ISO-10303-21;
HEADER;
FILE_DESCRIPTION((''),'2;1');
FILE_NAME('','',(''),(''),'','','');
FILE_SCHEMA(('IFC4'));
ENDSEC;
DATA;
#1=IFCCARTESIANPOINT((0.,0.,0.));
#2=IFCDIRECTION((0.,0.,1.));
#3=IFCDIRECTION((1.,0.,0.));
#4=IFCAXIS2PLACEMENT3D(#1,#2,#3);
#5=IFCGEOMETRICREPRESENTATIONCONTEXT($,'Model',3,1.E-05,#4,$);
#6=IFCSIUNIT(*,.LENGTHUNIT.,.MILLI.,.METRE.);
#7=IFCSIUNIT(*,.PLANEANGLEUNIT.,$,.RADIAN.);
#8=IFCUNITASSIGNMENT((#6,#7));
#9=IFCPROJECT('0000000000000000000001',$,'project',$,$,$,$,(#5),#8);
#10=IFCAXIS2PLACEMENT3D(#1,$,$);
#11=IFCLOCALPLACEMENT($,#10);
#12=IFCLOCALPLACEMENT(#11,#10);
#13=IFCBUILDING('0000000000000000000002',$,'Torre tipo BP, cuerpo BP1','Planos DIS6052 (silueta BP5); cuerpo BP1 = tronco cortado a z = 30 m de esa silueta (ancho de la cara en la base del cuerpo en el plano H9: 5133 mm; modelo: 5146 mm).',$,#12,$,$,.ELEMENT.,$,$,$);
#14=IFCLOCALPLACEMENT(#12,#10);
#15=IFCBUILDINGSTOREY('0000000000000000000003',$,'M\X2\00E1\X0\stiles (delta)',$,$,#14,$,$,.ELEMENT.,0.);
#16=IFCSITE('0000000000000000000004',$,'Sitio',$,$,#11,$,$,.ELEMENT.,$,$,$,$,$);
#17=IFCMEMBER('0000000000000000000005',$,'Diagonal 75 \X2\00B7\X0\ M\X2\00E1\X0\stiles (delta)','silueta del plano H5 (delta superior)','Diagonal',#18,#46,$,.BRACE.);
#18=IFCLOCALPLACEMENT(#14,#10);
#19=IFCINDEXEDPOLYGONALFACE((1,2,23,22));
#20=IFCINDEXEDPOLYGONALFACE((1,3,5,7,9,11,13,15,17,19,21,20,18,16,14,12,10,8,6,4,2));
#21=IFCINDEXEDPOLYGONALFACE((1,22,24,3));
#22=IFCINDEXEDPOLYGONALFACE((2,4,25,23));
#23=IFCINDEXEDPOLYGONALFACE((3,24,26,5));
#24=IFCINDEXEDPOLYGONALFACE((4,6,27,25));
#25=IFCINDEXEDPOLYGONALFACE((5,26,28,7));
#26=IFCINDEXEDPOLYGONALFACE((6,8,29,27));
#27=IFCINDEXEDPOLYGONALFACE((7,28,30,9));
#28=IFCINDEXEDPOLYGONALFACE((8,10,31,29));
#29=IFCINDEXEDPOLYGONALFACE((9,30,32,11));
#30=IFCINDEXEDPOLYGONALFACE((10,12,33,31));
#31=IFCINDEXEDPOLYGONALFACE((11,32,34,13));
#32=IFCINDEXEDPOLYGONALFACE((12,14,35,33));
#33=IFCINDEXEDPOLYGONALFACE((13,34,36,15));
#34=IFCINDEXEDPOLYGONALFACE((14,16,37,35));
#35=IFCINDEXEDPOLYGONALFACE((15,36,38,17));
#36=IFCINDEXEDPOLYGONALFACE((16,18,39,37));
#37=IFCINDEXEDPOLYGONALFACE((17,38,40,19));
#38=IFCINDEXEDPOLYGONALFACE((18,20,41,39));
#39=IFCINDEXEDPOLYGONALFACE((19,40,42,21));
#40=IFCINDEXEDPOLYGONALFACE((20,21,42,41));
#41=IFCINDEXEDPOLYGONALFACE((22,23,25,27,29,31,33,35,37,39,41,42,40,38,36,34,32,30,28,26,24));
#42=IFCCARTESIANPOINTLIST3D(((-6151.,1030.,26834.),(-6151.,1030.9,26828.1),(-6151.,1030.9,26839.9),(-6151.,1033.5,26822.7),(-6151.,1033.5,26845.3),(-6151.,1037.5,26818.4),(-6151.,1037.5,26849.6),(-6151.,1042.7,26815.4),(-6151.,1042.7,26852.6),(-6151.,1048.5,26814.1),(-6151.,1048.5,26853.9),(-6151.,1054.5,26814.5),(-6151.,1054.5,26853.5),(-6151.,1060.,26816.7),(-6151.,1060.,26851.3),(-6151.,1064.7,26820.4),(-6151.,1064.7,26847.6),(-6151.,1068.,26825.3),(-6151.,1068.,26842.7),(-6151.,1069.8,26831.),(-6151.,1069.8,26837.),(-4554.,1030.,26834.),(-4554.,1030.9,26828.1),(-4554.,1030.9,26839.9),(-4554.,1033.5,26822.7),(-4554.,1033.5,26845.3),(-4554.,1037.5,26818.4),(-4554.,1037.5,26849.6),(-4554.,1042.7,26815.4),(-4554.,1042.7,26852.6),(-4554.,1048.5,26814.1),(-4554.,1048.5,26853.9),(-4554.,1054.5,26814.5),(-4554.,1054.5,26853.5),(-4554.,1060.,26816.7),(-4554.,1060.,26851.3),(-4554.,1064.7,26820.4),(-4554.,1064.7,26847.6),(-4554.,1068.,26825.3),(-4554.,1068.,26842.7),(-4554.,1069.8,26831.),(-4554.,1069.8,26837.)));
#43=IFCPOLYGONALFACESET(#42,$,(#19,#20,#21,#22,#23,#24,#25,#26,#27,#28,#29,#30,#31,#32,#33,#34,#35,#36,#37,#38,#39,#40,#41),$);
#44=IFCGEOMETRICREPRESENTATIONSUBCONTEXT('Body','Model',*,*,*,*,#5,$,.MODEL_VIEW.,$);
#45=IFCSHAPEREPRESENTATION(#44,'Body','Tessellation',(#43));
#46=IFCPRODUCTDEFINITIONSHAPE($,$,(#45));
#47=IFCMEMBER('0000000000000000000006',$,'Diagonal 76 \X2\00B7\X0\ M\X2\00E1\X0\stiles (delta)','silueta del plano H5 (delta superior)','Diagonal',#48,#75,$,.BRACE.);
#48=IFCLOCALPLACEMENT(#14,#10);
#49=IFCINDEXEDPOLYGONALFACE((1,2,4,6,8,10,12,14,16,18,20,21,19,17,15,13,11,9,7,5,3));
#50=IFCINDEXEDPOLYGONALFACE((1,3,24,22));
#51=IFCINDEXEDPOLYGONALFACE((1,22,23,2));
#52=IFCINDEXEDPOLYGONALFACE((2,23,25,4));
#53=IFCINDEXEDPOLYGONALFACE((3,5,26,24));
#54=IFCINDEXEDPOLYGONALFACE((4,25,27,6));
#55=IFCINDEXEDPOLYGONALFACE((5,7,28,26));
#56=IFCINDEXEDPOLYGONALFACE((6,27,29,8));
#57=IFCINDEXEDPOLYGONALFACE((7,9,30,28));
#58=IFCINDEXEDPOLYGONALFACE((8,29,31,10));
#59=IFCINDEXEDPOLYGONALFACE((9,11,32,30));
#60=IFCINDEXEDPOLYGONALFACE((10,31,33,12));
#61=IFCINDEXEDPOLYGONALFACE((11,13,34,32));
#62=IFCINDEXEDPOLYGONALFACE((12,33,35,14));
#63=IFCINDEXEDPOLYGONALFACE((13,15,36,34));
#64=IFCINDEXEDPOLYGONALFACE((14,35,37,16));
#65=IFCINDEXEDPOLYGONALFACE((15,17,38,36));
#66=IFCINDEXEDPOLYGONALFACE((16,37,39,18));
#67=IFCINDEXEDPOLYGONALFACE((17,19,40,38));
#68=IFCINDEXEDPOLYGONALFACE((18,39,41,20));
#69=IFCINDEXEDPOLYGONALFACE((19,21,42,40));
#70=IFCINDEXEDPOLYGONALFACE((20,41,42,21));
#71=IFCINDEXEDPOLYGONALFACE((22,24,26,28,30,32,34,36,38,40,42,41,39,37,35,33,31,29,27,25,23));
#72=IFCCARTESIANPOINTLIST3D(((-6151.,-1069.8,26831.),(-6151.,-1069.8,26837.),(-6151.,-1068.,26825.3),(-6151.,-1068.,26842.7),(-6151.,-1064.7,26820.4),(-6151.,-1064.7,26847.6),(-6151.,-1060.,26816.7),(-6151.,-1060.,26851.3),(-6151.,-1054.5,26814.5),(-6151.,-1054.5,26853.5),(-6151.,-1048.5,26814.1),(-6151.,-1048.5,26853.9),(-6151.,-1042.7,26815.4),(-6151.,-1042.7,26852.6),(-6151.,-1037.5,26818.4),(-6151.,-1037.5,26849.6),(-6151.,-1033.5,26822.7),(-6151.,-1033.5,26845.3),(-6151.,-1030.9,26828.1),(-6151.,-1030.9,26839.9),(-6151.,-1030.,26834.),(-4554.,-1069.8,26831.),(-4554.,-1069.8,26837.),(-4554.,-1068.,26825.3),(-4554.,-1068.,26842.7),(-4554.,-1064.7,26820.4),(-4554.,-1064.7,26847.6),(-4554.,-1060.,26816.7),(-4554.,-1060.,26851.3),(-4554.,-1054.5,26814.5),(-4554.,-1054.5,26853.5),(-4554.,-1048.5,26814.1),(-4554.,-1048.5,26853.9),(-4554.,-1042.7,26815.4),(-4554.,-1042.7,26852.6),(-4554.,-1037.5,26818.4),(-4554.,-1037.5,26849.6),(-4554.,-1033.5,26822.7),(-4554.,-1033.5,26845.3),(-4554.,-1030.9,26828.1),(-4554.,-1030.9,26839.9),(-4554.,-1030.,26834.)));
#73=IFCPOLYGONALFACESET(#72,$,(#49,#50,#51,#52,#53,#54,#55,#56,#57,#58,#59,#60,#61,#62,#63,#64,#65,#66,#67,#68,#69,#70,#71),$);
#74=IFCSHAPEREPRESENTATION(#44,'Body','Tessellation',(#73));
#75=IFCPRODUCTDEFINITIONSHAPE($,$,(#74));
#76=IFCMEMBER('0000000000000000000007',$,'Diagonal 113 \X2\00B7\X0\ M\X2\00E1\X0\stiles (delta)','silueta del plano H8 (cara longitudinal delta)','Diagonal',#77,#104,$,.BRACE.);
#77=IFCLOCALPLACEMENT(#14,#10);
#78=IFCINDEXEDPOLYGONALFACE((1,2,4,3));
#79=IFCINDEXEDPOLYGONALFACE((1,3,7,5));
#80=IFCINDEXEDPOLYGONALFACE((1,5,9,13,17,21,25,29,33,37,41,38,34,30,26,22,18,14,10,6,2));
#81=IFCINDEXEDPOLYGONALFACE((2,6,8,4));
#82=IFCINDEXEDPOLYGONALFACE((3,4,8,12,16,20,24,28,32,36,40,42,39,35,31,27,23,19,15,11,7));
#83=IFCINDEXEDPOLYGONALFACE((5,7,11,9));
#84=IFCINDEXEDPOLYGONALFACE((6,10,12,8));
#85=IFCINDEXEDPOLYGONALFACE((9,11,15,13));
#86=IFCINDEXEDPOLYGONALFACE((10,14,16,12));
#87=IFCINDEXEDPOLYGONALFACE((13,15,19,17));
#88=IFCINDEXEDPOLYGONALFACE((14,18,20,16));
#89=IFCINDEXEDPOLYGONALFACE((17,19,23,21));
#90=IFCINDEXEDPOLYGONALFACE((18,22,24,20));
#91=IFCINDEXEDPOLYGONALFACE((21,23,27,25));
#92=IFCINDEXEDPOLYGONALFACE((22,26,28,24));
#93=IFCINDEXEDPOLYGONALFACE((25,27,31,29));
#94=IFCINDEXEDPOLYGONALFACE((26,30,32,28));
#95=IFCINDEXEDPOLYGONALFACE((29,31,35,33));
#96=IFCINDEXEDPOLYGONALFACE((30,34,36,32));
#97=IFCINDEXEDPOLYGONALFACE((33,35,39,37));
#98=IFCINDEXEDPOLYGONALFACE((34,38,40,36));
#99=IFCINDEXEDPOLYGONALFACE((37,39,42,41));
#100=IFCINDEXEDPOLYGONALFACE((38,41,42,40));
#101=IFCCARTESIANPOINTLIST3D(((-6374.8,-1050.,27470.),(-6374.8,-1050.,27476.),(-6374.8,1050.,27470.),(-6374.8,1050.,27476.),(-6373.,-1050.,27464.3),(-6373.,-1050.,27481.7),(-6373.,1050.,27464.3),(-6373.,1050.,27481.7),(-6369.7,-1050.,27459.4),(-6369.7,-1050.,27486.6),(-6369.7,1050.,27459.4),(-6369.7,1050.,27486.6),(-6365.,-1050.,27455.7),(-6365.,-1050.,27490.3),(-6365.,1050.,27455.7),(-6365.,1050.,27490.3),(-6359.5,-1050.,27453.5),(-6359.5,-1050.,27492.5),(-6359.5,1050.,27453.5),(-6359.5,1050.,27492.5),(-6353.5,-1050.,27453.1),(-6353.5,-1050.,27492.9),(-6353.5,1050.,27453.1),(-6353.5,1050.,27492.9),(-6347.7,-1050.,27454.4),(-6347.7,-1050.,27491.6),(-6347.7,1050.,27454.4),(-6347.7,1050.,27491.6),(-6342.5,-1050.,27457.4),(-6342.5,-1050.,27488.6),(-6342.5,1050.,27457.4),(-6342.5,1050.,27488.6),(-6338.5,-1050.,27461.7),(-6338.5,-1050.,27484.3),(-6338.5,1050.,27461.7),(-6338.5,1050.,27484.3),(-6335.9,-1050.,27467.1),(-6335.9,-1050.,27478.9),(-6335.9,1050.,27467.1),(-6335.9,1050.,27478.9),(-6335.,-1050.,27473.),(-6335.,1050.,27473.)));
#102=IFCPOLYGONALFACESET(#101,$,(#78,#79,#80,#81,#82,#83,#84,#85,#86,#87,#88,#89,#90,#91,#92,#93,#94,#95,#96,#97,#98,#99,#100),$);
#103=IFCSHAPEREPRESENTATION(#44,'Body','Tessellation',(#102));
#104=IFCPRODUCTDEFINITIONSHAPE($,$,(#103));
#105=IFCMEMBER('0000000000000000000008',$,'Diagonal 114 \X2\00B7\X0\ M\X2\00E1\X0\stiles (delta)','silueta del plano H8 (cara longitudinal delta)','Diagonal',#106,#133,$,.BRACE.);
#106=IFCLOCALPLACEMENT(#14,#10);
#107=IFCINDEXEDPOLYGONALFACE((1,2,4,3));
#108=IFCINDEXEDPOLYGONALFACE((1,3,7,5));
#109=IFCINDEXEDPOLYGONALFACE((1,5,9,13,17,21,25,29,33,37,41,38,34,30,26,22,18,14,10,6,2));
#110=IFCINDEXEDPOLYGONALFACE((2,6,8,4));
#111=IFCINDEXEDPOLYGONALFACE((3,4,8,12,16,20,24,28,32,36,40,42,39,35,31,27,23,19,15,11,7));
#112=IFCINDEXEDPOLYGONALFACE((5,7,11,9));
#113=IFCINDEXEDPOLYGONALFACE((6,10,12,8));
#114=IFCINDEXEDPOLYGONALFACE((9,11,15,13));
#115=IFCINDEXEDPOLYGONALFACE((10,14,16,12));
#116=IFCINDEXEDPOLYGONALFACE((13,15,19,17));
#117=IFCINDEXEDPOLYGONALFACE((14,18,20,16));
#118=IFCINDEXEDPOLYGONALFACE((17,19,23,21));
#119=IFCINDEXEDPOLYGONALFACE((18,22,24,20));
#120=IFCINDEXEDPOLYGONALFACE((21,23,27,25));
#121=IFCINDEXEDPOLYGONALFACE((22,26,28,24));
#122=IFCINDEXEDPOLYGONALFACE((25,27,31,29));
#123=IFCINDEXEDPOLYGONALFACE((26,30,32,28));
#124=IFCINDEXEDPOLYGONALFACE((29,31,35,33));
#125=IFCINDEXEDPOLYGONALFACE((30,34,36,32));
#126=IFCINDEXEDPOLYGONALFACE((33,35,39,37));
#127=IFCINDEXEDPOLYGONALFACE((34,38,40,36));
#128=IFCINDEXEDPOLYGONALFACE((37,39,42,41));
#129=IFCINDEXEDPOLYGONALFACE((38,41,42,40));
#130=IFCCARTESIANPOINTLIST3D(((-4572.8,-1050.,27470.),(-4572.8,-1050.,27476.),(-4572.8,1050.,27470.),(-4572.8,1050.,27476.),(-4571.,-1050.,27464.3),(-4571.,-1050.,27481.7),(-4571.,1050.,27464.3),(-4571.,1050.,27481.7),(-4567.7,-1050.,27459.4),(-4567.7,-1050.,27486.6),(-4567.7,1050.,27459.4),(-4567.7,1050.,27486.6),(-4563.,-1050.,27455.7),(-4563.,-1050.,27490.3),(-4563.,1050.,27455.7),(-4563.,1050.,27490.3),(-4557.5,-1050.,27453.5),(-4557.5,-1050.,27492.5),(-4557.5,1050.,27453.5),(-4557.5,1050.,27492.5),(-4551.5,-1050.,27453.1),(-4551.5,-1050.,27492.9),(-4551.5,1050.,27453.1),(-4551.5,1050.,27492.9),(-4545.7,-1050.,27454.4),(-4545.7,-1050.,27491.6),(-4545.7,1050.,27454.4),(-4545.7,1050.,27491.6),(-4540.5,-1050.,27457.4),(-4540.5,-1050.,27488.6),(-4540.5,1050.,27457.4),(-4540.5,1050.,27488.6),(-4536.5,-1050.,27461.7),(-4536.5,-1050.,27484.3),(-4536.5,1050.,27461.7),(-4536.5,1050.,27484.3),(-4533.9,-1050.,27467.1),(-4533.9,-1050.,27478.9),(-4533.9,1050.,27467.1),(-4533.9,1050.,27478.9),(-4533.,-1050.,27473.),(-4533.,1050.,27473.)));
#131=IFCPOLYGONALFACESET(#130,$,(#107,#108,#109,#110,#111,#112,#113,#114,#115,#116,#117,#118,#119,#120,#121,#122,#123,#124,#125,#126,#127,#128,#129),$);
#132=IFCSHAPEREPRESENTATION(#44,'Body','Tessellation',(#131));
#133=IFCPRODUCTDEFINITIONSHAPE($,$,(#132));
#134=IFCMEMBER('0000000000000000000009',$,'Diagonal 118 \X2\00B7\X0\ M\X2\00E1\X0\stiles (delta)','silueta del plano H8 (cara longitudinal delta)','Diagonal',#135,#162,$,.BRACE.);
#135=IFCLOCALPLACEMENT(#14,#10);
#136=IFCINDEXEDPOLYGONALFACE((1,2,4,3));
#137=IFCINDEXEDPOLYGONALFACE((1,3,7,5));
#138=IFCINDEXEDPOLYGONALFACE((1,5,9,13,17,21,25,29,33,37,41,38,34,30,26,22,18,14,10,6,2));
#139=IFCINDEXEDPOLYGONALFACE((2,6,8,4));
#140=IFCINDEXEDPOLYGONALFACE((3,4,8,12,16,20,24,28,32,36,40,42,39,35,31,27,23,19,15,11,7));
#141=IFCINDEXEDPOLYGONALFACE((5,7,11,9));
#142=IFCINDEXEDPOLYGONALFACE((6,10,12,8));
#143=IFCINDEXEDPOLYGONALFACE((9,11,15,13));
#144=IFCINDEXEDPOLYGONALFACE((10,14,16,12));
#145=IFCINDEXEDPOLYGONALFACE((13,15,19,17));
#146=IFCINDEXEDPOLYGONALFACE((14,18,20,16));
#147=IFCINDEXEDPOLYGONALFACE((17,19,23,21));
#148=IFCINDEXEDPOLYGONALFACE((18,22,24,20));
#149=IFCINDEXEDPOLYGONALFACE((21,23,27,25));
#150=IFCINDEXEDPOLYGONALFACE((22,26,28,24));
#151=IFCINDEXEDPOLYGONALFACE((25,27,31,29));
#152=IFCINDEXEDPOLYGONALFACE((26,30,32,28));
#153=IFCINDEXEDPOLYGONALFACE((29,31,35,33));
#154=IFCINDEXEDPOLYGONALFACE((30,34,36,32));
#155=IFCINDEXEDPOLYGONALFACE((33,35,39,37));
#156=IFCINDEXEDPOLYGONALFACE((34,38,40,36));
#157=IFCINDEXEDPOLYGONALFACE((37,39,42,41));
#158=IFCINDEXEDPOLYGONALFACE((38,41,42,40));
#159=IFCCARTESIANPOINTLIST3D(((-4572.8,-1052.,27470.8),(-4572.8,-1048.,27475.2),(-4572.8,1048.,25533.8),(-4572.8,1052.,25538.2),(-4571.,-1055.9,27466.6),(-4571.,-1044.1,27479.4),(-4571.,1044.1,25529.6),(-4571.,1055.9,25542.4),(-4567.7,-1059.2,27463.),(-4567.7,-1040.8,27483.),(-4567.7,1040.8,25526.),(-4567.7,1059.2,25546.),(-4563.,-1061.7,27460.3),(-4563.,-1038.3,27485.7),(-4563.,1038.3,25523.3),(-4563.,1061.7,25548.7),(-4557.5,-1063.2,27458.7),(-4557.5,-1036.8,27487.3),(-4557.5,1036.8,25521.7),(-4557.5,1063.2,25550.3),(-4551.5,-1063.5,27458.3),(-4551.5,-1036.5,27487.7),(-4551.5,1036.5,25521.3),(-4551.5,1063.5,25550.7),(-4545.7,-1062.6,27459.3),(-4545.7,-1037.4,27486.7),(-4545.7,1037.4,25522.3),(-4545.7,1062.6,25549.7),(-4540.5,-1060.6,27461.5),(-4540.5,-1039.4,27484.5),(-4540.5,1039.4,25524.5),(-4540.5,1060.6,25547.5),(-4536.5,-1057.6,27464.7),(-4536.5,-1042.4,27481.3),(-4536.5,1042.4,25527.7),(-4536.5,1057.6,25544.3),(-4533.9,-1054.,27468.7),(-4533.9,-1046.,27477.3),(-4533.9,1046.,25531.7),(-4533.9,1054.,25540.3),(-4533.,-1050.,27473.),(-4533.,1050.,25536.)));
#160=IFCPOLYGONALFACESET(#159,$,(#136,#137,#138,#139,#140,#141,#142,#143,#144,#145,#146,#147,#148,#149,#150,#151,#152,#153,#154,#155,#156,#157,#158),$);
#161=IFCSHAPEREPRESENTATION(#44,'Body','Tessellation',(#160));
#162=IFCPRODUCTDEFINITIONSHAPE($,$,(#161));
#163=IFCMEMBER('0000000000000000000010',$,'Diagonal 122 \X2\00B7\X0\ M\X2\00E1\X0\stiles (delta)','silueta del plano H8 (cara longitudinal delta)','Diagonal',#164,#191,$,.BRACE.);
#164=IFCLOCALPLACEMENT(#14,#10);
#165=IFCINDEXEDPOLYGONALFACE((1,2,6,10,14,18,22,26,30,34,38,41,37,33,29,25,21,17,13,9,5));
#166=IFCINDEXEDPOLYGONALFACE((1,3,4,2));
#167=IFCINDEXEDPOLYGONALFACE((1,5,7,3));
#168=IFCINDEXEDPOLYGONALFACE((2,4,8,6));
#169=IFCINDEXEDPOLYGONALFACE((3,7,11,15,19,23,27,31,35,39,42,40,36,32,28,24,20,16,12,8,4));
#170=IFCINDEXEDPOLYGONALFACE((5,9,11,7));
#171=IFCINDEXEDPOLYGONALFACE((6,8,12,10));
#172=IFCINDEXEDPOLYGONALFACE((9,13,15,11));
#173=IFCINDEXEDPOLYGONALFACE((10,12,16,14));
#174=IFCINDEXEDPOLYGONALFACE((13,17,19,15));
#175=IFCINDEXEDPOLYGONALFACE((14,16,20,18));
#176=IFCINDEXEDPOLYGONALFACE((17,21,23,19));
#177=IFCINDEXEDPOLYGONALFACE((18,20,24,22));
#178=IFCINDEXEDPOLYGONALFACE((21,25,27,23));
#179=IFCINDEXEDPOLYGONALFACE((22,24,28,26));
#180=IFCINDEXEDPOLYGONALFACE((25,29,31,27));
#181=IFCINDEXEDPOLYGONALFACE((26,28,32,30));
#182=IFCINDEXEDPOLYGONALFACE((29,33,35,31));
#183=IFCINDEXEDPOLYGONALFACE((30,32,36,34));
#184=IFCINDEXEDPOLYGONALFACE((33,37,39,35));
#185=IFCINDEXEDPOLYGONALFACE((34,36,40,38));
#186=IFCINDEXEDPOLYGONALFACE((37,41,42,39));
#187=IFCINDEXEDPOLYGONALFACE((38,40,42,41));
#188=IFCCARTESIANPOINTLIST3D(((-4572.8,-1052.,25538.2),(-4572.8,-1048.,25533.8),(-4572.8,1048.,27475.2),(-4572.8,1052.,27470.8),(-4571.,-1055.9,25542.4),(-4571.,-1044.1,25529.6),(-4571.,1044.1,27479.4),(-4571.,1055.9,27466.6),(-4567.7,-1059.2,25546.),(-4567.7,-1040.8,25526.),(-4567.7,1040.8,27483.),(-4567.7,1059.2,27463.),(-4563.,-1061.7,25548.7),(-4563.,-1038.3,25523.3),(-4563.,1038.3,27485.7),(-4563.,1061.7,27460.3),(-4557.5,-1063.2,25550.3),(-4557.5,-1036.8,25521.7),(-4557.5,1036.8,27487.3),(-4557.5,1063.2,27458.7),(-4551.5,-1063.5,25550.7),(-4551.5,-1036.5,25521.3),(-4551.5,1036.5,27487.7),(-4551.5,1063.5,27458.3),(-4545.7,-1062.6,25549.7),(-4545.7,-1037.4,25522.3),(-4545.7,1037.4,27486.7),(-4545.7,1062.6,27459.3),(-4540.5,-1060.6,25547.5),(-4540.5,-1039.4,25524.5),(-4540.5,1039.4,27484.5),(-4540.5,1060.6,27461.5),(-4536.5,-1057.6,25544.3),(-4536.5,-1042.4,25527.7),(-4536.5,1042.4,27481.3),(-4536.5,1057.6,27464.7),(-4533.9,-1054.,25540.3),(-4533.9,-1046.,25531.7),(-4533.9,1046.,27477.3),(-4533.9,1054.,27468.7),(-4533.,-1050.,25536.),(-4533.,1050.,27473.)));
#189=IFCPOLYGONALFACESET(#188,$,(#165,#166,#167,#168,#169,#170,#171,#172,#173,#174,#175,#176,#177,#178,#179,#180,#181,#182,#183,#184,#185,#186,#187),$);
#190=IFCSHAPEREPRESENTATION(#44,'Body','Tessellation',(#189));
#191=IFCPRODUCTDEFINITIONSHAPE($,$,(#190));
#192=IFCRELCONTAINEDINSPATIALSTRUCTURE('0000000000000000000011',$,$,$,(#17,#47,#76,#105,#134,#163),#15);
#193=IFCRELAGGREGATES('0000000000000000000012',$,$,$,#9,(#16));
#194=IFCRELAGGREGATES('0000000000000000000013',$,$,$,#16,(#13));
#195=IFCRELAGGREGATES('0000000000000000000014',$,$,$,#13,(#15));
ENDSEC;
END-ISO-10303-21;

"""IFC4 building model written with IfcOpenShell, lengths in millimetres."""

from ifc_helpers import new_model, si_unit, frame, origin, origin_with_axes, place, context, subcontext, project, spatial, circle, extrude, element, save


model = new_model("IFC4")

# Units and contexts
model_context = context("Model", 3, precision=1e-05, world=origin_with_axes())
body_context = subcontext(model_context, "Body", "Model", "MODEL_VIEW")
ifc_project = project(units=[si_unit("LENGTHUNIT", "METRE", prefix="MILLI"), si_unit("PLANEANGLEUNIT", "RADIAN")], contexts=[model_context])

# Site, building, storey
site_placement = place(None, origin())
site = spatial("IfcSite", under=ifc_project, at=site_placement, Name="Sitio", CompositionType="ELEMENT")
building_placement = place(site_placement, origin())
building = spatial("IfcBuilding", under=site, at=building_placement, Name="Torre tipo BP, cuerpo BP1", Description="Planos DIS6052 (silueta BP5); cuerpo BP1 = tronco cortado a z = 30 m de esa silueta (ancho de la cara en la base del cuerpo en el plano H9: 5133 mm; modelo: 5146 mm).", CompositionType="ELEMENT")
storey_placement = place(building_placement, origin())
storey = spatial("IfcBuildingStorey", under=building, at=storey_placement, Name="Mástiles (delta)", CompositionType="ELEMENT", Elevation=0.0)

# Members
for number, where, z_axis, x_axis, name in (
    (1, (-4554.0, 1050.0, 26834.0), (-1.0, 0.0, 0.0), (0.0, -1.0, 0.0), "Diagonal 75 · Mástiles (delta)"),
    (2, (-4554.0, -1050.0, 26834.0), (-1.0, 0.0, 0.0), (0.0, 1.0, 0.0), "Diagonal 76 · Mástiles (delta)"),
):
    element("IfcMember", number, at=place(storey_placement, frame(where, z_axis=z_axis, x_axis=x_axis)), inside=storey, Name=name, Description="silueta del plano H5 (delta superior)", ObjectType="Diagonal", PredefinedType="BRACE", context=body_context, shape_type="SweptSolid", body=[
        extrude(circle(Radius=20.0), None, (0.0, 0.0, 1.0), 1597.0),
    ])
for number, where, z_axis, x_axis, name in (
    (3, (-6355.0, -1050.0, 27473.0), (0.0, 1.0, 0.0), (1.0, 0.0, 0.0), "Diagonal 113 · Mástiles (delta)"),
    (4, (-4553.0, -1050.0, 27473.0), (0.0, 1.0, 0.0), (1.0, 0.0, 0.0), "Diagonal 114 · Mástiles (delta)"),
):
    element("IfcMember", number, at=place(storey_placement, frame(where, z_axis=z_axis, x_axis=x_axis)), inside=storey, Name=name, Description="silueta del plano H8 (cara longitudinal delta)", ObjectType="Diagonal", PredefinedType="BRACE", context=body_context, shape_type="SweptSolid", body=[
        extrude(circle(Radius=20.0), None, (0.0, 0.0, 1.0), 2100.0),
    ])
member_1_placement = place(storey_placement, frame((-4553.0, -1050.0, 27473.0), z_axis=(0.0, 0.735058, -0.678004), x_axis=(1.0, 0.0, 0.0)))
element("IfcMember", 5, at=member_1_placement, inside=storey, Name="Diagonal 118 · Mástiles (delta)", Description="silueta del plano H8 (cara longitudinal delta)", ObjectType="Diagonal", PredefinedType="BRACE", context=body_context, shape_type="SweptSolid", body=[
    extrude(circle(Radius=20.0), None, (0.0, 0.0, 1.0), 2856.9),
])
member_2_placement = place(storey_placement, frame((-4553.0, 1050.0, 27473.0), z_axis=(0.0, -0.735058, -0.678004), x_axis=(1.0, 0.0, 0.0)))
element("IfcMember", 6, at=member_2_placement, inside=storey, Name="Diagonal 122 · Mástiles (delta)", Description="silueta del plano H8 (cara longitudinal delta)", ObjectType="Diagonal", PredefinedType="BRACE", context=body_context, shape_type="SweptSolid", body=[
    extrude(circle(Radius=20.0), None, (0.0, 0.0, 1.0), 2856.9),
])

save(model, "model.ifc")
